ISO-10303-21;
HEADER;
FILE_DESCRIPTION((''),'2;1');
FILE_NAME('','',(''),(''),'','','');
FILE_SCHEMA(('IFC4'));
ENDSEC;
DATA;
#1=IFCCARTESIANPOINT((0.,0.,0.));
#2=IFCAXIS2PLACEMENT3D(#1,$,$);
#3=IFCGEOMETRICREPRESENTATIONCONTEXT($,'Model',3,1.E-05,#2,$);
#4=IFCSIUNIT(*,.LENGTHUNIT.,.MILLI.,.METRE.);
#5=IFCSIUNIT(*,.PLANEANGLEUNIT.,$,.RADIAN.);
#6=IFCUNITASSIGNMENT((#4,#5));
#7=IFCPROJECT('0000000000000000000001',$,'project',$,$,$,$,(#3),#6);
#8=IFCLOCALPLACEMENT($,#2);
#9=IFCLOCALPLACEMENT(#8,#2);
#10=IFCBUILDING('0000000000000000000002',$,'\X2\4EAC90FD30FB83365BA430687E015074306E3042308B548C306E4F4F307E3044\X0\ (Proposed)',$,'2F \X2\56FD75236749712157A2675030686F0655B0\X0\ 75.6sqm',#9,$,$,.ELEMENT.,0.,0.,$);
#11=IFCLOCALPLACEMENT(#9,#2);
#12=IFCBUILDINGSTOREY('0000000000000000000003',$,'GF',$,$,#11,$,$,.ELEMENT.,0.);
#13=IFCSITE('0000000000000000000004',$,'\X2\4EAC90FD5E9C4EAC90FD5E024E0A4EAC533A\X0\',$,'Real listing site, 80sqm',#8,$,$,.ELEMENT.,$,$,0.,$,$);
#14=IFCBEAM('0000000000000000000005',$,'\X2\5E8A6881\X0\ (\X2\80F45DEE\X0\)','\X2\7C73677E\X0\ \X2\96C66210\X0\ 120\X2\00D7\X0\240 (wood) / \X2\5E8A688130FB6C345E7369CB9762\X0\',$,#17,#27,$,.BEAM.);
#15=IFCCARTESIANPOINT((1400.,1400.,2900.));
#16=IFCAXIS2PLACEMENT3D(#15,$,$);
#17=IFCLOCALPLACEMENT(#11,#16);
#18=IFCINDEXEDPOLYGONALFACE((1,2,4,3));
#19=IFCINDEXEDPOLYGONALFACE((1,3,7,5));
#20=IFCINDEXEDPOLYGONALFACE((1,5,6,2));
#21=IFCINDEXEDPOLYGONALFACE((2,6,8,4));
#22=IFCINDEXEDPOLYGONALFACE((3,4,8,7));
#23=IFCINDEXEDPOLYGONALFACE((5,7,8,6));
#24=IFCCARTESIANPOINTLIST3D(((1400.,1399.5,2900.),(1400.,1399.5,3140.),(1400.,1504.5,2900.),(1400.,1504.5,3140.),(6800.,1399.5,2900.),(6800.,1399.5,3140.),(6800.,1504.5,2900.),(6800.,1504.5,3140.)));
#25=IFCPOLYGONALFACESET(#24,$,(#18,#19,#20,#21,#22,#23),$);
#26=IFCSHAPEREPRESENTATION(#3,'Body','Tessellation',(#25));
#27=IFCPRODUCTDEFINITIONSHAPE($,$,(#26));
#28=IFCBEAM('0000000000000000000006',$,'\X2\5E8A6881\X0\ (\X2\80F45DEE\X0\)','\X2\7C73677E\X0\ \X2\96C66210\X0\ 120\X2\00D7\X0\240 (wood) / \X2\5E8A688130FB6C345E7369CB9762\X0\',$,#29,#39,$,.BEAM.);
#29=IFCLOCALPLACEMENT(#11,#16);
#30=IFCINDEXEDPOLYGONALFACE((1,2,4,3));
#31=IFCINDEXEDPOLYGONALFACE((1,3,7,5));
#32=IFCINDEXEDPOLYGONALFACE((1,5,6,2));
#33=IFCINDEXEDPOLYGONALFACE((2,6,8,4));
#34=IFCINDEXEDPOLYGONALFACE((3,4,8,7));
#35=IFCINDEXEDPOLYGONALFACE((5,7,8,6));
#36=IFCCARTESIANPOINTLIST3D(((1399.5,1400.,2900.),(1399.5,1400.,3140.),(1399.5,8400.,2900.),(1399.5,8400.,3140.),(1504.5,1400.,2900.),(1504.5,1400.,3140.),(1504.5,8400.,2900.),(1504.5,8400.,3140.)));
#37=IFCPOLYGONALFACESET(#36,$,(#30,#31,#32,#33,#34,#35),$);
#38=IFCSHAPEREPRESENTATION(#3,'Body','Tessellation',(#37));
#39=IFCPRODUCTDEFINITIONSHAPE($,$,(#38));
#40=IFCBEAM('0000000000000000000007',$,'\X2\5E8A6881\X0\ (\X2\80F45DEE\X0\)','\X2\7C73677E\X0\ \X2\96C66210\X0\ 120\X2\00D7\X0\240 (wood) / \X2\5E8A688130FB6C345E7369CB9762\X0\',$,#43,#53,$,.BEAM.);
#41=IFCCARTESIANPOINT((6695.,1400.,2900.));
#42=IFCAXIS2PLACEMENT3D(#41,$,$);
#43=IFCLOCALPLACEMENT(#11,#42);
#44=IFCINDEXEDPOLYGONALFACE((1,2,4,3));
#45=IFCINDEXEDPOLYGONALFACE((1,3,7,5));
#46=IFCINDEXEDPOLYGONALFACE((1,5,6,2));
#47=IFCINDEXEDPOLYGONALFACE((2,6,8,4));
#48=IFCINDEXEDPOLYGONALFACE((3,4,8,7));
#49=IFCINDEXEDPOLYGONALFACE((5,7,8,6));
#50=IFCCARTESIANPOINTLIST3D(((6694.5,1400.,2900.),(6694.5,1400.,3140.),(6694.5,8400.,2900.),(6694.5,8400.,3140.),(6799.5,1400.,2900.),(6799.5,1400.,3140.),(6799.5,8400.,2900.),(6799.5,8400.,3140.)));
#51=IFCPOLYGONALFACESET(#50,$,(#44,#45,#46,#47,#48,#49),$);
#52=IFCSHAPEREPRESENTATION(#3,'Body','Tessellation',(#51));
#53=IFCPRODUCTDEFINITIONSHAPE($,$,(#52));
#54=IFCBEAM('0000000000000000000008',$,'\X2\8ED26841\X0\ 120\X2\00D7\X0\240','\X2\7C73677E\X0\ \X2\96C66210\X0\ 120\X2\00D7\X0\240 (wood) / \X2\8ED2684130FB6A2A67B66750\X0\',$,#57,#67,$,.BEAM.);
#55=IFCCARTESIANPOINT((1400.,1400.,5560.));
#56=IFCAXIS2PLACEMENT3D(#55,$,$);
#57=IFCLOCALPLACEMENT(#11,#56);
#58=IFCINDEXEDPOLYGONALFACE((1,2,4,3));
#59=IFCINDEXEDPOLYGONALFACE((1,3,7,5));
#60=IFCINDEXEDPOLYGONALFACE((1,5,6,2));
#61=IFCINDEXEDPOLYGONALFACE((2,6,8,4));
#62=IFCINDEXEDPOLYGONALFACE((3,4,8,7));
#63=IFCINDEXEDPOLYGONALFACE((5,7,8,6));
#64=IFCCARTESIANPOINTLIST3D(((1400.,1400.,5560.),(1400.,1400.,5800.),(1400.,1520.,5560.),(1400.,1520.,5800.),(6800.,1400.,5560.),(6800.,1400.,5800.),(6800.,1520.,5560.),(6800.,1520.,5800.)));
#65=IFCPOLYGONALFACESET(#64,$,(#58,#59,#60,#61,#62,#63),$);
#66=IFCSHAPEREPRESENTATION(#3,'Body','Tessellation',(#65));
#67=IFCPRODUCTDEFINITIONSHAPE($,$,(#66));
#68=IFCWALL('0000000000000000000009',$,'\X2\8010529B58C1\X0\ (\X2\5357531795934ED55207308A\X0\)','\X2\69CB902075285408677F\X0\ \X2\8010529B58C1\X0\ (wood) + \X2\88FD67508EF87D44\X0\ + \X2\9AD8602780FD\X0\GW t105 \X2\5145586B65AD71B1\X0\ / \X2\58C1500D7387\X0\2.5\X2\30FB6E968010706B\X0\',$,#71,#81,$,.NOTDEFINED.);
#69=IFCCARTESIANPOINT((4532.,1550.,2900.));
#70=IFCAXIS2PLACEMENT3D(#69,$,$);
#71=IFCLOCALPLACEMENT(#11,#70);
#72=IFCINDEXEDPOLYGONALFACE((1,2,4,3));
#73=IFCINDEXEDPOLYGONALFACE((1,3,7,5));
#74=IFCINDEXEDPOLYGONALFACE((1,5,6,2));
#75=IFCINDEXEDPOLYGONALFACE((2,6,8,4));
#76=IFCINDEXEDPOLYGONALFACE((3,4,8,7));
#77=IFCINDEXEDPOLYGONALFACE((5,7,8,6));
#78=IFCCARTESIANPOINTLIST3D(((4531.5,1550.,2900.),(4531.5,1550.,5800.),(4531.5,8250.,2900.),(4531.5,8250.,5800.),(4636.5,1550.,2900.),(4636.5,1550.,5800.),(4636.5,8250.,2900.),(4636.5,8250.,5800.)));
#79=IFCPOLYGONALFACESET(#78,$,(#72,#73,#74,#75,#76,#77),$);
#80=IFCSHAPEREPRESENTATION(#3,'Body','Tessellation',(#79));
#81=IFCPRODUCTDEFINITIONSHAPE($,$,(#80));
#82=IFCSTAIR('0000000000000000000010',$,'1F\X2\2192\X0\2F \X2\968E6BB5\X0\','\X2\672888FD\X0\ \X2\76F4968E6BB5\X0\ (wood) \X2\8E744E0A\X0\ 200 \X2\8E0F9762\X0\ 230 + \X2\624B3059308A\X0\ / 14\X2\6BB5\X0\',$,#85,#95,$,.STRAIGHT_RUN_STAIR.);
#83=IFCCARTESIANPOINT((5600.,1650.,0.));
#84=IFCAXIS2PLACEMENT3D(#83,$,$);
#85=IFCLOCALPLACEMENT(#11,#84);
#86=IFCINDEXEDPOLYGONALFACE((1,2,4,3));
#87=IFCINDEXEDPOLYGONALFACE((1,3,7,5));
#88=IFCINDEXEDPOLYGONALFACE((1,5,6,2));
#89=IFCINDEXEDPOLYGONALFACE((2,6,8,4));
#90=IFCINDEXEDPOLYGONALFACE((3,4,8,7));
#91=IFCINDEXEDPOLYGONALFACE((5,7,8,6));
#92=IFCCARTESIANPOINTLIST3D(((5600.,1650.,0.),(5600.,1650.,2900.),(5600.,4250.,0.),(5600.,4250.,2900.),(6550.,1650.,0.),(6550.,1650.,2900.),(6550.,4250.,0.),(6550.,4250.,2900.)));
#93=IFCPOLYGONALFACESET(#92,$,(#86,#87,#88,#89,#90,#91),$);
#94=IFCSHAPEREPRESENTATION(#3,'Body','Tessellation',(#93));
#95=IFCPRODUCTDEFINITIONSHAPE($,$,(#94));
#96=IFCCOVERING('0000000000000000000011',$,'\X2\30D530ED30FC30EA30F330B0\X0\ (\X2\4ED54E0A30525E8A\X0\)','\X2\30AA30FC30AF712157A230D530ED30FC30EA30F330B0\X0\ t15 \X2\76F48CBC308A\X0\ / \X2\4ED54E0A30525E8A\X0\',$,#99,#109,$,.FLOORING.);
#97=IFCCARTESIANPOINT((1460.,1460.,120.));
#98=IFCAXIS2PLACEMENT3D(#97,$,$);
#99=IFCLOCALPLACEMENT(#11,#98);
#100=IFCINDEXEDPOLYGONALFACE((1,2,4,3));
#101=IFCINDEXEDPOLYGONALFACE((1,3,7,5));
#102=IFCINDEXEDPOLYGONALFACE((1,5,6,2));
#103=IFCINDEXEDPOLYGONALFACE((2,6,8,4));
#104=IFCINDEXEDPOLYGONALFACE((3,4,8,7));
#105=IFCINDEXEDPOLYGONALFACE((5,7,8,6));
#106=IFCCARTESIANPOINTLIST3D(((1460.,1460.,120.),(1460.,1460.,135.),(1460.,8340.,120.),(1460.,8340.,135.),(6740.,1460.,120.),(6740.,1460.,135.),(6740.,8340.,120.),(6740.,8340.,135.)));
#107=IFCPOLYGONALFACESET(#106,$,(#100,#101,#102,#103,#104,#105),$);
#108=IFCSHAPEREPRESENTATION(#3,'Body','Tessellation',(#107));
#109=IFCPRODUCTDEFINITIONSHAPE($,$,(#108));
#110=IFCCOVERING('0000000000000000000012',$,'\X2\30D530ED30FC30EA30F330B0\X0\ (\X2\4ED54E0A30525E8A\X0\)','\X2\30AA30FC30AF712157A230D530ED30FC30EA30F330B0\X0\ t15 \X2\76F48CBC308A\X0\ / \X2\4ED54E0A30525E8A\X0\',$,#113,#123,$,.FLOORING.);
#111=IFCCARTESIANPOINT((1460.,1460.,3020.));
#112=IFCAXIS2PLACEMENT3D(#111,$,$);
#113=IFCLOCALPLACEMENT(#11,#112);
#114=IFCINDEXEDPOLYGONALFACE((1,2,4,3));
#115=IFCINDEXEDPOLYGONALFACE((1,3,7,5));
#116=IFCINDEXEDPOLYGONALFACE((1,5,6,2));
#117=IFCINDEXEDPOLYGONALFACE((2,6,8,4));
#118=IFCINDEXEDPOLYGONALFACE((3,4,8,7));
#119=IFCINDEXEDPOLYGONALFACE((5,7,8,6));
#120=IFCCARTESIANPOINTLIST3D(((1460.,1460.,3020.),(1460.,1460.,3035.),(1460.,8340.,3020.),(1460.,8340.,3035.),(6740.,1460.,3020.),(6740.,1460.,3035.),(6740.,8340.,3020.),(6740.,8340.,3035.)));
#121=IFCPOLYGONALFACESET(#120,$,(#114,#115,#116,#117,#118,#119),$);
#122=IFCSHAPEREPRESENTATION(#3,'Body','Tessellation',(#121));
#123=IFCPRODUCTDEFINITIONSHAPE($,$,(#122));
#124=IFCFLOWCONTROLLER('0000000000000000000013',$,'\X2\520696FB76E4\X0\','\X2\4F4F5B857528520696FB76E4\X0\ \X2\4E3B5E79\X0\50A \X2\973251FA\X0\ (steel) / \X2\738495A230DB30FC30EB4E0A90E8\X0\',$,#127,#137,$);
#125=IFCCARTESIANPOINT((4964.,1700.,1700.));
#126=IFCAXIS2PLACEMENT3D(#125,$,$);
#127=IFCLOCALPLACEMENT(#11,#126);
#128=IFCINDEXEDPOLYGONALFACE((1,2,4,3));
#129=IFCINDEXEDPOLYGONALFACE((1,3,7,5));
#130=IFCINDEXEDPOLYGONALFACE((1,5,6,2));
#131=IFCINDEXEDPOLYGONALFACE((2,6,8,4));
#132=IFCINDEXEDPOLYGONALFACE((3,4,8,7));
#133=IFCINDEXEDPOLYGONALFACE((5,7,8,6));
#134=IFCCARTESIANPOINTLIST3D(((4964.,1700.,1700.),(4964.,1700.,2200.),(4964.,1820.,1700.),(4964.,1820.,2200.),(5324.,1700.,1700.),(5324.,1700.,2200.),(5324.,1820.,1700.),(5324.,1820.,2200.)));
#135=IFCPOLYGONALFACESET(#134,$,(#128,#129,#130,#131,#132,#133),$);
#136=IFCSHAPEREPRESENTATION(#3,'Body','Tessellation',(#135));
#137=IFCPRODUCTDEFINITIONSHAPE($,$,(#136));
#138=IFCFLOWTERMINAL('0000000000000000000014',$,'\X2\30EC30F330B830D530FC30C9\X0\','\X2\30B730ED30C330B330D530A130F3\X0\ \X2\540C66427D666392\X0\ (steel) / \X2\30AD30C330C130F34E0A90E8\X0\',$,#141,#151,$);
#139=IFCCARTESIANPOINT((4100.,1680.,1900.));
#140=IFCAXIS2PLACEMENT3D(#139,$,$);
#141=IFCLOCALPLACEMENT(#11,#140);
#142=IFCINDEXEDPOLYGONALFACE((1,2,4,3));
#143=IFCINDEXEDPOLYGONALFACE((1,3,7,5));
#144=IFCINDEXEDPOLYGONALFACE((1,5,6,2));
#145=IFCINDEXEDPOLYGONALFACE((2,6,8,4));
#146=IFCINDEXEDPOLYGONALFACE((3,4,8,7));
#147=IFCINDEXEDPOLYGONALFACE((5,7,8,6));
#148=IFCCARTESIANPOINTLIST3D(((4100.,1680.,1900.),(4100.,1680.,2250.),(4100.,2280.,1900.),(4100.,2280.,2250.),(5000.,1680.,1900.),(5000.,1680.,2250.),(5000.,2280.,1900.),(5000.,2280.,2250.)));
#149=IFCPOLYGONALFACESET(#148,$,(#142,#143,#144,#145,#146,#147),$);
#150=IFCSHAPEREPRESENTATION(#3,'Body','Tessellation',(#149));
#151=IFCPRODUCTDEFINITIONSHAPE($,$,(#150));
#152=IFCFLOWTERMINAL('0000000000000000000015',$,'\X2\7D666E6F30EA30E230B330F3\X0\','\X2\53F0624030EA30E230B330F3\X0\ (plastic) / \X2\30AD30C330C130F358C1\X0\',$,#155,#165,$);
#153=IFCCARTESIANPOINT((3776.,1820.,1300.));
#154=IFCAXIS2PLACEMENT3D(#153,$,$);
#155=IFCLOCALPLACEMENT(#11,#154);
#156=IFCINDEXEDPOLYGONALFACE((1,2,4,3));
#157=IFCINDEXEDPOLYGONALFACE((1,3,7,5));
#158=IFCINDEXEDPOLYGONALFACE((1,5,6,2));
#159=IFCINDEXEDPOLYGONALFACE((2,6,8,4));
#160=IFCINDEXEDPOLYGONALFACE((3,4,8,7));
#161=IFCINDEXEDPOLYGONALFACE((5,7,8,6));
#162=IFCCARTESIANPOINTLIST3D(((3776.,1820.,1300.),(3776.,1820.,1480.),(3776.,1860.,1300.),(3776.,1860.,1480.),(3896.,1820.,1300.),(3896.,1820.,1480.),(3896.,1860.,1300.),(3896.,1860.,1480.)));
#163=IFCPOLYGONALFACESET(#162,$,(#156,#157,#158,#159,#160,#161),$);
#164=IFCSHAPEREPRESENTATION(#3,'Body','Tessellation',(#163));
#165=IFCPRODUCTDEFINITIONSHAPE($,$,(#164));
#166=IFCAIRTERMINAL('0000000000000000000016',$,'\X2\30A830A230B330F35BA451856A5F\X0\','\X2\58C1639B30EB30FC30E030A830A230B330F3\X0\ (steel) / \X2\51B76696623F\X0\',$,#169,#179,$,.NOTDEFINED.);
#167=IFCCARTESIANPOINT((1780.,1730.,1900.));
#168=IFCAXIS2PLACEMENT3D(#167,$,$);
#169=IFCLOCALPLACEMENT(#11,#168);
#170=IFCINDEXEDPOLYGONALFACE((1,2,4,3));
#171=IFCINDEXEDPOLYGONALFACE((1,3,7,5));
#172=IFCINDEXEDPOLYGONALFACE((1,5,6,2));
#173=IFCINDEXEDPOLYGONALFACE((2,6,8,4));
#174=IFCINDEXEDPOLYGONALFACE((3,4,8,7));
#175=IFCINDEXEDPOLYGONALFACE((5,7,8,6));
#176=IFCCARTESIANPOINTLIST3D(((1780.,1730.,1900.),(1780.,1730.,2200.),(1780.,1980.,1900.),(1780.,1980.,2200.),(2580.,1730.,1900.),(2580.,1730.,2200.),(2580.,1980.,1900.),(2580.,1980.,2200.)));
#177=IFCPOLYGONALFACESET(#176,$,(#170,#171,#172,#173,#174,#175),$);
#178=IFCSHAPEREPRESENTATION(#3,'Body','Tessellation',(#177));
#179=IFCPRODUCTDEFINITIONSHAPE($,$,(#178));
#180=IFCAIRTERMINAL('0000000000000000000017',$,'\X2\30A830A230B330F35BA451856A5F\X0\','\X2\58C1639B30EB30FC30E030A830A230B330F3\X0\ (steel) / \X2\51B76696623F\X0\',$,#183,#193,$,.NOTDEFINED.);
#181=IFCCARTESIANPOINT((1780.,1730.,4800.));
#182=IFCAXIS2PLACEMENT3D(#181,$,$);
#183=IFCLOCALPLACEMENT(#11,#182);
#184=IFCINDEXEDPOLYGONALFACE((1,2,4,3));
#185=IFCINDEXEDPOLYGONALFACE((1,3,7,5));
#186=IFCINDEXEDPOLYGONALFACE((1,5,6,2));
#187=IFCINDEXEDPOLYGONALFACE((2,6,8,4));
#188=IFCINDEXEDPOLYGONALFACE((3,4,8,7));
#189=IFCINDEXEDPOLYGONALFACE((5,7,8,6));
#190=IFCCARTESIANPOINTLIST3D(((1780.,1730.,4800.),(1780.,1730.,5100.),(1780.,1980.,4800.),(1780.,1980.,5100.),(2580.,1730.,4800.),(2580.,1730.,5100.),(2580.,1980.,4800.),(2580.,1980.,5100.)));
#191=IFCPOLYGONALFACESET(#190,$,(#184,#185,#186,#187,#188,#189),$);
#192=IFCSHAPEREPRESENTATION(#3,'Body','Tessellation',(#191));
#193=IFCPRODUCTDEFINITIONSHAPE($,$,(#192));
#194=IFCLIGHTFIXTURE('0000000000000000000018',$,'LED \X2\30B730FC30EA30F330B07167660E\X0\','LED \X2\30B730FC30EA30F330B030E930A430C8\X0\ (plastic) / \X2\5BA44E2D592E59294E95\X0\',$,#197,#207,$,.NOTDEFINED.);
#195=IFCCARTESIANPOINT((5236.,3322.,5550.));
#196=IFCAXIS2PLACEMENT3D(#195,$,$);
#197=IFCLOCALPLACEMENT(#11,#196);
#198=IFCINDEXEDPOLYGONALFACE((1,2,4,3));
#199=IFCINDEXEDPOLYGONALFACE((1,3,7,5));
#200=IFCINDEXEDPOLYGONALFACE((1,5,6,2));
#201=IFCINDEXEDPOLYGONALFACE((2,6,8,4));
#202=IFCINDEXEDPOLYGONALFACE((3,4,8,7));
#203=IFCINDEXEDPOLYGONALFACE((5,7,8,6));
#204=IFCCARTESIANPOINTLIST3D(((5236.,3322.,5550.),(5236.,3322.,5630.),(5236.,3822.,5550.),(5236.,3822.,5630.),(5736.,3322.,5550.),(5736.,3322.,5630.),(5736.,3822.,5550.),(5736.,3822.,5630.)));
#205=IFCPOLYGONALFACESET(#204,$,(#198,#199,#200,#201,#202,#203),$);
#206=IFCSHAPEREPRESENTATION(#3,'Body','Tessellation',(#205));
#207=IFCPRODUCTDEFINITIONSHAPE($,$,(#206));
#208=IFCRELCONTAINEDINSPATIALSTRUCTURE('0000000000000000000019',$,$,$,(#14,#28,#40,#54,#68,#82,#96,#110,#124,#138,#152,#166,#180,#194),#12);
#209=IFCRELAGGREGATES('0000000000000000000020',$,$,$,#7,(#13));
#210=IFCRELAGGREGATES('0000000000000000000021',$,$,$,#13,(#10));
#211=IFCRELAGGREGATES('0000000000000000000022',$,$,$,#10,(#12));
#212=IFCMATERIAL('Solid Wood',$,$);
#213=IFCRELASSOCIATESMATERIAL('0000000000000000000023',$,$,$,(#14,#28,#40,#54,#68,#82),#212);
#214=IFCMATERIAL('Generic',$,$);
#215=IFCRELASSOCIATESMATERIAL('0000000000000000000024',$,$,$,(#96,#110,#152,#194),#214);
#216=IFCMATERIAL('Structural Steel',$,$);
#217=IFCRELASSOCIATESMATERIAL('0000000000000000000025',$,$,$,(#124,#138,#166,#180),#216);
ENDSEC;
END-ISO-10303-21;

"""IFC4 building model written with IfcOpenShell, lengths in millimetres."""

from ifc_helpers import new_model, si_unit, frame, frame_2d, origin, place, context, project, spatial, rectangle, extrude, material, element, save


model = new_model("IFC4")

# Units and contexts
model_context = context("Model", 3, precision=1e-05, world=origin())
ifc_project = project(units=[si_unit("LENGTHUNIT", "METRE", prefix="MILLI"), si_unit("PLANEANGLEUNIT", "RADIAN")], contexts=[model_context])

# Site, building, storey
site_placement = place(None, origin())
site = spatial("IfcSite", under=ifc_project, at=site_placement, Name="京都府京都市上京区", ObjectType="Real listing site, 80sqm", CompositionType="ELEMENT", RefElevation=0.0)
building_placement = place(site_placement, origin())
building = spatial("IfcBuilding", under=site, at=building_placement, Name="京都・茶室と縁側のある和の住まい (Proposed)", ObjectType="2F 国産杉無垢材と漆喰 75.6sqm", CompositionType="ELEMENT", ElevationOfRefHeight=0.0, ElevationOfTerrain=0.0)
storey_placement = place(building_placement, origin())
storey = spatial("IfcBuildingStorey", under=building, at=storey_placement, Name="GF", CompositionType="ELEMENT", Elevation=0.0)

# Shared definitions
ifc_material_1 = material(Name="Solid Wood")

# Beams
beam_1_placement = place(storey_placement, frame((1400.0, 1400.0, 2900.0)))
element("IfcBeam", 1, at=beam_1_placement, inside=storey, material=ifc_material_1, Name="床梁 (胴差)", Description="米松 集成 120×240 (wood) / 床梁・水平構面", PredefinedType="BEAM", context=model_context, shape_type="SweptSolid", body=[
    extrude(rectangle(XDim=5400.0, YDim=105.0, at=frame_2d((2700.0, 52.0))), frame((1400.0, 1400.0, 2900.0)), (0.0, 0.0, 1.0), 240.0),
])
beam_2_placement = place(storey_placement, frame((1400.0, 1400.0, 2900.0)))
element("IfcBeam", 2, at=beam_2_placement, inside=storey, material=ifc_material_1, Name="床梁 (胴差)", Description="米松 集成 120×240 (wood) / 床梁・水平構面", PredefinedType="BEAM", context=model_context, shape_type="SweptSolid", body=[
    extrude(rectangle(XDim=105.0, YDim=7000.0, at=frame_2d((52.0, 3500.0))), frame((1400.0, 1400.0, 2900.0)), (0.0, 0.0, 1.0), 240.0),
])
beam_3_placement = place(storey_placement, frame((6695.0, 1400.0, 2900.0)))
element("IfcBeam", 3, at=beam_3_placement, inside=storey, material=ifc_material_1, Name="床梁 (胴差)", Description="米松 集成 120×240 (wood) / 床梁・水平構面", PredefinedType="BEAM", context=model_context, shape_type="SweptSolid", body=[
    extrude(rectangle(XDim=105.0, YDim=7000.0, at=frame_2d((52.0, 3500.0))), frame((6695.0, 1400.0, 2900.0)), (0.0, 0.0, 1.0), 240.0),
])
beam_4_placement = place(storey_placement, frame((1400.0, 1400.0, 5560.0)))
element("IfcBeam", 4, at=beam_4_placement, inside=storey, material=ifc_material_1, Name="軒桁 120×240", Description="米松 集成 120×240 (wood) / 軒桁・横架材", PredefinedType="BEAM", context=model_context, shape_type="SweptSolid", body=[
    extrude(rectangle(XDim=5400.0, YDim=120.0, at=frame_2d((2700.0, 60.0))), frame((1400.0, 1400.0, 5560.0)), (0.0, 0.0, 1.0), 240.0),
])

# Wall
wall_1_placement = place(storey_placement, frame((4532.0, 1550.0, 2900.0)))
element("IfcWall", 5, at=wall_1_placement, inside=storey, material=ifc_material_1, Name="耐力壁 (南北間仕切り)", Description="構造用合板 耐力壁 (wood) + 製材軸組 + 高性能GW t105 充填断熱 / 壁倍率2.5・準耐火", PredefinedType="NOTDEFINED", context=model_context, shape_type="SweptSolid", body=[
    extrude(rectangle(XDim=105.0, YDim=6700.0, at=frame_2d((52.0, 3350.0))), frame((4532.0, 1550.0, 2900.0)), (0.0, 0.0, 1.0), 2900.0),
])

# Stair
stair_placement = place(storey_placement, frame((5600.0, 1650.0, 0.0)))
element("IfcStair", 6, at=stair_placement, inside=storey, material=ifc_material_1, Name="1F→2F 階段", Description="木製 直階段 (wood) 蹴上 200 踏面 230 + 手すり / 14段", PredefinedType="STRAIGHT_RUN_STAIR", context=model_context, shape_type="SweptSolid", body=[
    extrude(rectangle(XDim=950.0, YDim=2600.0, at=frame_2d((475.0, 1300.0))), frame((5600.0, 1650.0, 0.0)), (0.0, 0.0, 1.0), 2900.0),
])

# Coverings
ifc_material_2 = material(Name="Generic")
covering_1_placement = place(storey_placement, frame((1460.0, 1460.0, 120.0)))
element("IfcCovering", 7, at=covering_1_placement, inside=storey, material=ifc_material_2, Name="フローリング (仕上げ床)", Description="オーク無垢フローリング t15 直貼り / 仕上げ床", PredefinedType="FLOORING", context=model_context, shape_type="SweptSolid", body=[
    extrude(rectangle(XDim=5280.0, YDim=6880.0, at=frame_2d((2640.0, 3440.0))), frame((1460.0, 1460.0, 120.0)), (0.0, 0.0, 1.0), 15.0),
])
covering_2_placement = place(storey_placement, frame((1460.0, 1460.0, 3020.0)))
element("IfcCovering", 8, at=covering_2_placement, inside=storey, material=ifc_material_2, Name="フローリング (仕上げ床)", Description="オーク無垢フローリング t15 直貼り / 仕上げ床", PredefinedType="FLOORING", context=model_context, shape_type="SweptSolid", body=[
    extrude(rectangle(XDim=5280.0, YDim=6880.0, at=frame_2d((2640.0, 3440.0))), frame((1460.0, 1460.0, 3020.0)), (0.0, 0.0, 1.0), 15.0),
])

# Flow controller
ifc_material_3 = material(Name="Structural Steel")
flow_controller_placement = place(storey_placement, frame((4964.0, 1700.0, 1700.0)))
element("IfcFlowController", 9, at=flow_controller_placement, inside=storey, material=ifc_material_3, Name="分電盤", Description="住宅用分電盤 主幹50A 露出 (steel) / 玄関ホール上部", context=model_context, shape_type="SweptSolid", body=[
    extrude(rectangle(XDim=360.0, YDim=120.0, at=frame_2d((180.0, 60.0))), frame((4964.0, 1700.0, 1700.0)), (0.0, 0.0, 1.0), 500.0),
])

# Flow terminals
flow_terminal_1_placement = place(storey_placement, frame((4100.0, 1680.0, 1900.0)))
element("IfcFlowTerminal", 10, at=flow_terminal_1_placement, inside=storey, material=ifc_material_3, Name="レンジフード", Description="シロッコファン 同時給排 (steel) / キッチン上部", context=model_context, shape_type="SweptSolid", body=[
    extrude(rectangle(XDim=900.0, YDim=600.0, at=frame_2d((450.0, 300.0))), frame((4100.0, 1680.0, 1900.0)), (0.0, 0.0, 1.0), 350.0),
])
flow_terminal_2_placement = place(storey_placement, frame((3776.0, 1820.0, 1300.0)))
element("IfcFlowTerminal", 11, at=flow_terminal_2_placement, inside=storey, material=ifc_material_2, Name="給湯リモコン", Description="台所リモコン (plastic) / キッチン壁", context=model_context, shape_type="SweptSolid", body=[
    extrude(rectangle(XDim=120.0, YDim=40.0, at=frame_2d((60.0, 20.0))), frame((3776.0, 1820.0, 1300.0)), (0.0, 0.0, 1.0), 180.0),
])

# Air terminals
air_terminal_1_placement = place(storey_placement, frame((1780.0, 1730.0, 1900.0)))
element("IfcAirTerminal", 12, at=air_terminal_1_placement, inside=storey, material=ifc_material_3, Name="エアコン室内機", Description="壁掛ルームエアコン (steel) / 冷暖房", PredefinedType="NOTDEFINED", context=model_context, shape_type="SweptSolid", body=[
    extrude(rectangle(XDim=800.0, YDim=250.0, at=frame_2d((400.0, 125.0))), frame((1780.0, 1730.0, 1900.0)), (0.0, 0.0, 1.0), 300.0),
])
air_terminal_2_placement = place(storey_placement, frame((1780.0, 1730.0, 4800.0)))
element("IfcAirTerminal", 13, at=air_terminal_2_placement, inside=storey, material=ifc_material_3, Name="エアコン室内機", Description="壁掛ルームエアコン (steel) / 冷暖房", PredefinedType="NOTDEFINED", context=model_context, shape_type="SweptSolid", body=[
    extrude(rectangle(XDim=800.0, YDim=250.0, at=frame_2d((400.0, 125.0))), frame((1780.0, 1730.0, 4800.0)), (0.0, 0.0, 1.0), 300.0),
])

# Light fixture
light_fixture_placement = place(storey_placement, frame((5236.0, 3322.0, 5550.0)))
element("IfcLightFixture", 14, at=light_fixture_placement, inside=storey, material=ifc_material_2, Name="LED シーリング照明", Description="LED シーリングライト (plastic) / 室中央天井", PredefinedType="NOTDEFINED", context=model_context, shape_type="SweptSolid", body=[
    extrude(rectangle(XDim=500.0, YDim=500.0, at=frame_2d((250.0, 250.0))), frame((5236.0, 3322.0, 5550.0)), (0.0, 0.0, 1.0), 80.0),
])

save(model, "model.ifc")
